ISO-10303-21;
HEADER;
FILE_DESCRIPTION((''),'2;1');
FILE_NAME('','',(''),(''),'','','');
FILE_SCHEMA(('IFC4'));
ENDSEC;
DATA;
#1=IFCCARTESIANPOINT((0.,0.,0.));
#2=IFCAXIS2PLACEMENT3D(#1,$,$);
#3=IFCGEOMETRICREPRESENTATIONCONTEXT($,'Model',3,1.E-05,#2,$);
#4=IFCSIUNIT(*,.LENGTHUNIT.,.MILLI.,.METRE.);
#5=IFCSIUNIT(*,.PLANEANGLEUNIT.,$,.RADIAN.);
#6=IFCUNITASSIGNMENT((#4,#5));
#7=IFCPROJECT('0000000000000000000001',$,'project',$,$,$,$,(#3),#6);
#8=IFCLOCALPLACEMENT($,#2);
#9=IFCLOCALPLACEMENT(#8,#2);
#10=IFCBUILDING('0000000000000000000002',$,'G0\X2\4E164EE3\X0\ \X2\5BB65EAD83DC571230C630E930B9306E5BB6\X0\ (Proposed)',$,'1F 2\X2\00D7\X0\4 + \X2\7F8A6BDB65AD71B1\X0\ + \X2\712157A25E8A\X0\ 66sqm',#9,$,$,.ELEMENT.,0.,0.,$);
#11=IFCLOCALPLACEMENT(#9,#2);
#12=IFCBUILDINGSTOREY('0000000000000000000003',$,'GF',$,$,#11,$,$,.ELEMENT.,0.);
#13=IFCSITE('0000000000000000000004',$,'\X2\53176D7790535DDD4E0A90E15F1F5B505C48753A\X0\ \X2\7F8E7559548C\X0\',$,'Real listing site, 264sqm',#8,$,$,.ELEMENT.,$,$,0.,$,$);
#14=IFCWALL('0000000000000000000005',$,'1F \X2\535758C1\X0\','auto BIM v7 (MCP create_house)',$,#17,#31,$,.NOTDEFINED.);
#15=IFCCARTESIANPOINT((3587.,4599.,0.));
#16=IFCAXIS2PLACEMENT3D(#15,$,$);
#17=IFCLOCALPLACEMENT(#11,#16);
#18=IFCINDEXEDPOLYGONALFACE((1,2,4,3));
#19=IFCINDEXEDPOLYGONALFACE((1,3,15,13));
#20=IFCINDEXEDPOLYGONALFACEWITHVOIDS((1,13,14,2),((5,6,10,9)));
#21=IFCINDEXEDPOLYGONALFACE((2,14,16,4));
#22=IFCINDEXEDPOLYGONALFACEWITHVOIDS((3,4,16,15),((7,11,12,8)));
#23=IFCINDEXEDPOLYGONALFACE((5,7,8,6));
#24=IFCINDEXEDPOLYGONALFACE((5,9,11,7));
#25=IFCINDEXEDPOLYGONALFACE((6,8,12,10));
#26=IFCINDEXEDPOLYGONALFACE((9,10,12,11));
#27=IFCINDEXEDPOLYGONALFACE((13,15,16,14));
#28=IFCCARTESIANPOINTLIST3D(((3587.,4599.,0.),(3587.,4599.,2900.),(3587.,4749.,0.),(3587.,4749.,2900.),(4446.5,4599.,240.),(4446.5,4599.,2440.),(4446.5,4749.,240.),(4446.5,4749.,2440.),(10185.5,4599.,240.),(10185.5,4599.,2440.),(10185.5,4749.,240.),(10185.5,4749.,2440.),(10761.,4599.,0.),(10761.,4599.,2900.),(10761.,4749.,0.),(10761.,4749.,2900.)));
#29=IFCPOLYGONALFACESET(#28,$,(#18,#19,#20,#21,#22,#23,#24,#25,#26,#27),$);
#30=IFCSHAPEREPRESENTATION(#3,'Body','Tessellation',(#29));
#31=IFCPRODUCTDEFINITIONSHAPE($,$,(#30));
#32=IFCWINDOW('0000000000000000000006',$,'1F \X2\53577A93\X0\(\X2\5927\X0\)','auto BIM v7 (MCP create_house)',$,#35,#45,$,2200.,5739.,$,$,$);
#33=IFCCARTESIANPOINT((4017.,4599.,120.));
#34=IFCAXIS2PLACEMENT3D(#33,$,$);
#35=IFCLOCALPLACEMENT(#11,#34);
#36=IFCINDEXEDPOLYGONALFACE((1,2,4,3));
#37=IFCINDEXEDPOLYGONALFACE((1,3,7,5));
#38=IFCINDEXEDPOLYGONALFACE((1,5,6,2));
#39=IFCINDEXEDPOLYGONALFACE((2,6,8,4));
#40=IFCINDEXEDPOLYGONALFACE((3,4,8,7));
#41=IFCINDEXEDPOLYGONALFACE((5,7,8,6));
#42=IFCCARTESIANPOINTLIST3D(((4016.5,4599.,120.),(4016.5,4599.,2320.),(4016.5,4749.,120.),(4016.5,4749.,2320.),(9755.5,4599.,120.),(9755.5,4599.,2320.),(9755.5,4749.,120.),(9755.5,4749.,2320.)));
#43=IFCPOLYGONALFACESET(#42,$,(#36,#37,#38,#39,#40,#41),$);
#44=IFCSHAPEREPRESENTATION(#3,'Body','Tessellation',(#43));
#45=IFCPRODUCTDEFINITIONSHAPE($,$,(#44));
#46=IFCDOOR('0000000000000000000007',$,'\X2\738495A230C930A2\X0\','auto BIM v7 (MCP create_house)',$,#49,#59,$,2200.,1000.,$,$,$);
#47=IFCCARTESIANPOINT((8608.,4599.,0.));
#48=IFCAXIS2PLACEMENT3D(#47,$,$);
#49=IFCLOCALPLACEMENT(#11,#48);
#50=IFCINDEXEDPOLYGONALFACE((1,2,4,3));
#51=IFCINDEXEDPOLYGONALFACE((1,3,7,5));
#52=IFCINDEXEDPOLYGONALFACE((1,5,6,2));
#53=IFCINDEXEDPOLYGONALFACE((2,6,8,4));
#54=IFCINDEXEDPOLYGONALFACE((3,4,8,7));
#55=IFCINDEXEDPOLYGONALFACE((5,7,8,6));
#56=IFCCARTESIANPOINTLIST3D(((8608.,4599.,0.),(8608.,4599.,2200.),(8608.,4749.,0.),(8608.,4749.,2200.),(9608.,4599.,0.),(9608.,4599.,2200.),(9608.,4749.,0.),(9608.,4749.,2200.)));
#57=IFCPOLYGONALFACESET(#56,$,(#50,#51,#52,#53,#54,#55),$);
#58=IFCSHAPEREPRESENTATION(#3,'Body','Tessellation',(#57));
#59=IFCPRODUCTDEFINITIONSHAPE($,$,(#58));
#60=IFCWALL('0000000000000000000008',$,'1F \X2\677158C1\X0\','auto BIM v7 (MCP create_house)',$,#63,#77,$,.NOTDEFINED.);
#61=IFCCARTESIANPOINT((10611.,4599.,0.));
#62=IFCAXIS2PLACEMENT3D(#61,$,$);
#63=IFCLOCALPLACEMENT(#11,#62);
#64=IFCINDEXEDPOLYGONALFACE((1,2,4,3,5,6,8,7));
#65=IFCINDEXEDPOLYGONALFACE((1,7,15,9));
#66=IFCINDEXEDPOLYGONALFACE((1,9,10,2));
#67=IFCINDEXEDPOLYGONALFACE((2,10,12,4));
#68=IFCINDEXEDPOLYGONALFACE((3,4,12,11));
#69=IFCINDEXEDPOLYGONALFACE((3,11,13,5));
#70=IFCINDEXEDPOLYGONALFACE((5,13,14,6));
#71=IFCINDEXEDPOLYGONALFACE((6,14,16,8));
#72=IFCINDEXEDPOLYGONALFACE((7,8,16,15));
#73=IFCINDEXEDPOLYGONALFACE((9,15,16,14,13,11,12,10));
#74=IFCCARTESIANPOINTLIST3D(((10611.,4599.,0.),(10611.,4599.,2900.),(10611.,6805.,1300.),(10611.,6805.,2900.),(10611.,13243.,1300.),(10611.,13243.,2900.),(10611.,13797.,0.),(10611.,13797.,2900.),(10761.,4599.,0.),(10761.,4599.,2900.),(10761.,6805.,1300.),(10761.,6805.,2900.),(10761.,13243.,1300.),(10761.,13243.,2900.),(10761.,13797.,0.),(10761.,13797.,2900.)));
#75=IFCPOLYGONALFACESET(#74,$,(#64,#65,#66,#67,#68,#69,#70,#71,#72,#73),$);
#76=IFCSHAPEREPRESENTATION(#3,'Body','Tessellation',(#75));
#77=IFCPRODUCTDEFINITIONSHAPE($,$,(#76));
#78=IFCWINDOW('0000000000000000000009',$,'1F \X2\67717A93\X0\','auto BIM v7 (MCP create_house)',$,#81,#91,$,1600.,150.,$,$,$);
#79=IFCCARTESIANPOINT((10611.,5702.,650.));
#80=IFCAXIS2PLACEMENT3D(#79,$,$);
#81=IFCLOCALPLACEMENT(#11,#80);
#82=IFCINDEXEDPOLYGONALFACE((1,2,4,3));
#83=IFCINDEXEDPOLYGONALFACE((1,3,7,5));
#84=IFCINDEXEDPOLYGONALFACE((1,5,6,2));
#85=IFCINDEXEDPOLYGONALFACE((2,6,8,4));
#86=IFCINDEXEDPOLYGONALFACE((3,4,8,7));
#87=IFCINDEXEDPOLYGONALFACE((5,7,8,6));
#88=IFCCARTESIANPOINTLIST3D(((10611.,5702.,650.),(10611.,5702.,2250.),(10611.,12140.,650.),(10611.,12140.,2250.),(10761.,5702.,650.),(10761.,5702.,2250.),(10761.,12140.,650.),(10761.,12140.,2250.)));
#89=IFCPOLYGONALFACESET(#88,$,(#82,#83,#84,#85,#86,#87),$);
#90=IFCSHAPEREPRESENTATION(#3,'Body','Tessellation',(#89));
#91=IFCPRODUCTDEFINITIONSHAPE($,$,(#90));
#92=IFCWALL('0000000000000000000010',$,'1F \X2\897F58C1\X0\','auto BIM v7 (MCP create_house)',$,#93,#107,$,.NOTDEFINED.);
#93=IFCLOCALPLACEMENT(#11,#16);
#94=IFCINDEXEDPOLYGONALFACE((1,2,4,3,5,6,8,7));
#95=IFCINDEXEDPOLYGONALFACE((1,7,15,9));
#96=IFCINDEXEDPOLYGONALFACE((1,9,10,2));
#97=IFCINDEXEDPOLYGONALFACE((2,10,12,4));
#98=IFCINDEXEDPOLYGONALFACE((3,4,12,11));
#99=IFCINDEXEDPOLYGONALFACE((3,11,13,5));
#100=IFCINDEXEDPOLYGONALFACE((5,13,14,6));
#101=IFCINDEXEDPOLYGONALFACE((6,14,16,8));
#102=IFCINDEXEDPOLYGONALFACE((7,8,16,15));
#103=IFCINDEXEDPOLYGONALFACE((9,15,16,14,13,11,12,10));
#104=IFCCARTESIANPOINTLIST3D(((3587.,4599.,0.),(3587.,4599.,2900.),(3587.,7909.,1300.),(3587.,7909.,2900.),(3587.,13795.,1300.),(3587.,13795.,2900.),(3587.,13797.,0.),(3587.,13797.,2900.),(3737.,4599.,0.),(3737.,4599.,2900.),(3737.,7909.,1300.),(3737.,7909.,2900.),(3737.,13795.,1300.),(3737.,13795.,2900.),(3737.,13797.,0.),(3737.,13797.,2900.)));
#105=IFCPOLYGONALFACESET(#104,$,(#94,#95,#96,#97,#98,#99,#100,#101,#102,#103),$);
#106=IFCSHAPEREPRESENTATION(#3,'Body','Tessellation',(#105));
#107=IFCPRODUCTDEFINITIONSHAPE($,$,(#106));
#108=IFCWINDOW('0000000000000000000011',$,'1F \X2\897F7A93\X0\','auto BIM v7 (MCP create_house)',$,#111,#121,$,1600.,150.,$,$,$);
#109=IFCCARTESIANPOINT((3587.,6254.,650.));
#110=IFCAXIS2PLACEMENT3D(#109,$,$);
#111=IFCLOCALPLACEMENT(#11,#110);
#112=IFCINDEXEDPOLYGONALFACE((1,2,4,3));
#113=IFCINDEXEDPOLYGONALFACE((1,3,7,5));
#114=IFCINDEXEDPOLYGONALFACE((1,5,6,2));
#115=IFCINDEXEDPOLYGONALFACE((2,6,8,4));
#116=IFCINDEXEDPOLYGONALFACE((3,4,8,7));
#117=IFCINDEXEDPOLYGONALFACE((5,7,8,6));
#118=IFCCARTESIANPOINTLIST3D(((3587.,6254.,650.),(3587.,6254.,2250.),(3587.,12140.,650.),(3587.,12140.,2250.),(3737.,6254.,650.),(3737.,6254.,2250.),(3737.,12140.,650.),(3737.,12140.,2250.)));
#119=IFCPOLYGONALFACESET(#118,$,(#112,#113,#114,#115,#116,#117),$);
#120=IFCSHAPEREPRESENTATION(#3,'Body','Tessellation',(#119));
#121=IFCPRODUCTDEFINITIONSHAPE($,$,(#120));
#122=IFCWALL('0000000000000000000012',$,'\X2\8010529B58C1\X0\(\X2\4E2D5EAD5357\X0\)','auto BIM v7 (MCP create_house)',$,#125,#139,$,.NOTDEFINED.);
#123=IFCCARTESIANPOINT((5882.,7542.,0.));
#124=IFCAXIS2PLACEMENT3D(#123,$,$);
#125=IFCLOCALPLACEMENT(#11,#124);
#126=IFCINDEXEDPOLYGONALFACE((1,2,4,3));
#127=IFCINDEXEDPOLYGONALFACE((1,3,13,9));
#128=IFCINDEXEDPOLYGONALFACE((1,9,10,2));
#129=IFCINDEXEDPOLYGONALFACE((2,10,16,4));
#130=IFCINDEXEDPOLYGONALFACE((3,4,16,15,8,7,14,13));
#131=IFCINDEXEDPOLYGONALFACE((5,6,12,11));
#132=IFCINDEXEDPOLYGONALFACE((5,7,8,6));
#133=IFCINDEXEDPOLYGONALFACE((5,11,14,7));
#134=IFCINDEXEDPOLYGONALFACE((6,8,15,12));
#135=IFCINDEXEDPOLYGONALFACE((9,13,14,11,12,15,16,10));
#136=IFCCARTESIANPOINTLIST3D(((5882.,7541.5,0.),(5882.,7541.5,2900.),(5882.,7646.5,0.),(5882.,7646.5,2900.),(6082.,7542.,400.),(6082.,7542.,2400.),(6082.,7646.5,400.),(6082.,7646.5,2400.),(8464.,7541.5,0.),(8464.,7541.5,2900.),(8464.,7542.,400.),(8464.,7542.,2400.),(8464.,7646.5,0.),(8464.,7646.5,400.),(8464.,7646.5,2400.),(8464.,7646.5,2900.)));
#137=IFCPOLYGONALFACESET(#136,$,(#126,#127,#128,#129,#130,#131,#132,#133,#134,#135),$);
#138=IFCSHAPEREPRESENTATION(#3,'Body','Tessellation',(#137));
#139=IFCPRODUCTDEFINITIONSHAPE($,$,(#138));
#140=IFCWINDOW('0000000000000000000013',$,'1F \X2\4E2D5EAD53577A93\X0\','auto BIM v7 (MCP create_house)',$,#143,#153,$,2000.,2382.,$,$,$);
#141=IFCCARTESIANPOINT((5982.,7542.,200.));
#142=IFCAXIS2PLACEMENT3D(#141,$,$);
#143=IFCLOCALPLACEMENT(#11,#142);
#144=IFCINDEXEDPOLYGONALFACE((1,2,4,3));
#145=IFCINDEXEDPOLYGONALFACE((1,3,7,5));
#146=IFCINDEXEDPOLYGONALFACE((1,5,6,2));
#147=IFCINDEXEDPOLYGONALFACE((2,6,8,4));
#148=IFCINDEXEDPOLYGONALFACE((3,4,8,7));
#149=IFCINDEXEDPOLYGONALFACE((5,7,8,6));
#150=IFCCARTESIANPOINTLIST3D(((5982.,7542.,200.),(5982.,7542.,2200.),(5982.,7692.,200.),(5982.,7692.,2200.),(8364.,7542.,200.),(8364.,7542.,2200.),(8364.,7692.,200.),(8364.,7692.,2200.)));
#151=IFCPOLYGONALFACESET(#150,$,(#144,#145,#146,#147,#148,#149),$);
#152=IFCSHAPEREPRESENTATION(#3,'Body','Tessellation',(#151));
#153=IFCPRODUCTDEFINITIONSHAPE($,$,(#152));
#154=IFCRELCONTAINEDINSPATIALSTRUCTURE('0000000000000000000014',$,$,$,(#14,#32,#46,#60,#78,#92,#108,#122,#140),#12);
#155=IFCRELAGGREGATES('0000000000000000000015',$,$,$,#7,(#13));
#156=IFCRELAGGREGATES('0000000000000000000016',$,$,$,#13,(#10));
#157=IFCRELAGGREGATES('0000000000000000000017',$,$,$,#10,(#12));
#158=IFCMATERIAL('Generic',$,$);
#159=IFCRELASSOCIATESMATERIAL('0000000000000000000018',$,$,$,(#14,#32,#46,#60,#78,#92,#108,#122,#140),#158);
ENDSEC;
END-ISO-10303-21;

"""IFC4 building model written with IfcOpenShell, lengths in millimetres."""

from ifc_helpers import new_model, si_unit, frame, frame_2d, origin, place, context, project, spatial, rectangle, extrude, material, element, fill, save


model = new_model("IFC4")

# Units and contexts
model_context = context("Model", 3, precision=1e-05, world=origin())
ifc_project = project(units=[si_unit("LENGTHUNIT", "METRE", prefix="MILLI"), si_unit("PLANEANGLEUNIT", "RADIAN")], contexts=[model_context])

# Site, building, storey
site_placement = place(None, origin())
site = spatial("IfcSite", under=ifc_project, at=site_placement, Name="北海道川上郡弟子屈町 美留和", ObjectType="Real listing site, 264sqm", CompositionType="ELEMENT", RefElevation=0.0)
building_placement = place(site_placement, origin())
building = spatial("IfcBuilding", under=site, at=building_placement, Name="G0世代 家庭菜園テラスの家 (Proposed)", ObjectType="1F 2×4 + 羊毛断熱 + 無垢床 66sqm", CompositionType="ELEMENT", ElevationOfRefHeight=0.0, ElevationOfTerrain=0.0)
storey_placement = place(building_placement, origin())
storey = spatial("IfcBuildingStorey", under=building, at=storey_placement, Name="GF", CompositionType="ELEMENT", Elevation=0.0)

# Shared definitions
ifc_material = material(Name="Generic")

# Wall, openings, window, door
wall_1_placement = place(storey_placement, frame((3587.0, 4599.0, 0.0)))
wall_1 = element("IfcWall", 1, at=wall_1_placement, inside=storey, material=ifc_material, Name="1F 南壁", Description="auto BIM v7 (MCP create_house)", PredefinedType="NOTDEFINED", context=model_context, shape_type="SweptSolid", body=[
    extrude(rectangle(XDim=7174.0, YDim=150.0, at=frame_2d((3587.0, 75.0))), frame((3587.0, 4599.0, 0.0)), (0.0, 0.0, 1.0), 2900.0),
])
opening_1_placement = place(storey_placement, frame((4017.0, 4599.0, 120.0)))
opening_1 = element("IfcOpeningElement", 2, at=opening_1_placement, cuts=wall_1, PredefinedType="NOTDEFINED", context=model_context, shape_type="SweptSolid", body=[
    extrude(rectangle(XDim=5739.0, YDim=150.0, at=frame_2d((2869.0, 75.0))), frame((4017.0, 4599.0, 120.0)), (0.0, 0.0, 1.0), 2200.0),
])
opening_2_placement = place(storey_placement, frame((8608.0, 4599.0, 0.0)))
opening_2 = element("IfcOpeningElement", 3, at=opening_2_placement, cuts=wall_1, PredefinedType="NOTDEFINED", context=model_context, shape_type="SweptSolid", body=[
    extrude(rectangle(XDim=1000.0, YDim=150.0, at=frame_2d((500.0, 75.0))), frame((8608.0, 4599.0, 0.0)), (0.0, 0.0, 1.0), 2200.0),
])
window_1_placement = place(storey_placement, frame((4017.0, 4599.0, 120.0)))
window_1 = element("IfcWindow", 4, at=window_1_placement, inside=storey, material=ifc_material, Name="1F 南窓(大)", Description="auto BIM v7 (MCP create_house)", OverallHeight=2200.0, OverallWidth=5739.0, context=model_context, shape_type="SweptSolid", body=[
    extrude(rectangle(XDim=5739.0, YDim=150.0, at=frame_2d((2869.0, 75.0))), frame((4017.0, 4599.0, 120.0)), (0.0, 0.0, 1.0), 2200.0),
])
fill(opening_1, window_1)
door_placement = place(storey_placement, frame((8608.0, 4599.0, 0.0)))
door = element("IfcDoor", 5, at=door_placement, inside=storey, material=ifc_material, Name="玄関ドア", Description="auto BIM v7 (MCP create_house)", OverallHeight=2200.0, OverallWidth=1000.0, context=model_context, shape_type="SweptSolid", body=[
    extrude(rectangle(XDim=1000.0, YDim=150.0, at=frame_2d((500.0, 75.0))), frame((8608.0, 4599.0, 0.0)), (0.0, 0.0, 1.0), 2200.0),
])
fill(opening_2, door)

# Walls, openings, windows
wall_2_placement = place(storey_placement, frame((10611.0, 4599.0, 0.0)))
wall_2 = element("IfcWall", 6, at=wall_2_placement, inside=storey, material=ifc_material, Name="1F 東壁", Description="auto BIM v7 (MCP create_house)", PredefinedType="NOTDEFINED", context=model_context, shape_type="SweptSolid", body=[
    extrude(rectangle(XDim=150.0, YDim=9198.0, at=frame_2d((75.0, 4599.0))), frame((10611.0, 4599.0, 0.0)), (0.0, 0.0, 1.0), 2900.0),
])
opening_3_placement = place(storey_placement, frame((10611.0, 5702.0, 650.0)))
opening_3 = element("IfcOpeningElement", 7, at=opening_3_placement, cuts=wall_2, PredefinedType="NOTDEFINED", context=model_context, shape_type="SweptSolid", body=[
    extrude(rectangle(XDim=150.0, YDim=6438.0, at=frame_2d((75.0, 3219.0))), frame((10611.0, 5702.0, 650.0)), (0.0, 0.0, 1.0), 1600.0),
])
window_2_placement = place(storey_placement, frame((10611.0, 5702.0, 650.0)))
window_2 = element("IfcWindow", 8, at=window_2_placement, inside=storey, material=ifc_material, Name="1F 東窓", Description="auto BIM v7 (MCP create_house)", OverallHeight=1600.0, OverallWidth=150.0, context=model_context, shape_type="SweptSolid", body=[
    extrude(rectangle(XDim=150.0, YDim=6438.0, at=frame_2d((75.0, 3219.0))), frame((10611.0, 5702.0, 650.0)), (0.0, 0.0, 1.0), 1600.0),
])
fill(opening_3, window_2)
wall_3_placement = place(storey_placement, frame((3587.0, 4599.0, 0.0)))
wall_3 = element("IfcWall", 9, at=wall_3_placement, inside=storey, material=ifc_material, Name="1F 西壁", Description="auto BIM v7 (MCP create_house)", PredefinedType="NOTDEFINED", context=model_context, shape_type="SweptSolid", body=[
    extrude(rectangle(XDim=150.0, YDim=9198.0, at=frame_2d((75.0, 4599.0))), frame((3587.0, 4599.0, 0.0)), (0.0, 0.0, 1.0), 2900.0),
])
opening_4_placement = place(storey_placement, frame((3587.0, 6254.0, 650.0)))
opening_4 = element("IfcOpeningElement", 10, at=opening_4_placement, cuts=wall_3, PredefinedType="NOTDEFINED", context=model_context, shape_type="SweptSolid", body=[
    extrude(rectangle(XDim=150.0, YDim=5886.0, at=frame_2d((75.0, 2943.0))), frame((3587.0, 6254.0, 650.0)), (0.0, 0.0, 1.0), 1600.0),
])
window_3_placement = place(storey_placement, frame((3587.0, 6254.0, 650.0)))
window_3 = element("IfcWindow", 11, at=window_3_placement, inside=storey, material=ifc_material, Name="1F 西窓", Description="auto BIM v7 (MCP create_house)", OverallHeight=1600.0, OverallWidth=150.0, context=model_context, shape_type="SweptSolid", body=[
    extrude(rectangle(XDim=150.0, YDim=5886.0, at=frame_2d((75.0, 2943.0))), frame((3587.0, 6254.0, 650.0)), (0.0, 0.0, 1.0), 1600.0),
])
fill(opening_4, window_3)
wall_4_placement = place(storey_placement, frame((5882.0, 7542.0, 0.0)))
wall_4 = element("IfcWall", 12, at=wall_4_placement, inside=storey, material=ifc_material, Name="耐力壁(中庭南)", Description="auto BIM v7 (MCP create_house)", PredefinedType="NOTDEFINED", context=model_context, shape_type="SweptSolid", body=[
    extrude(rectangle(XDim=2582.0, YDim=105.0, at=frame_2d((1291.0, 52.0))), frame((5882.0, 7542.0, 0.0)), (0.0, 0.0, 1.0), 2900.0),
])
opening_5_placement = place(storey_placement, frame((5982.0, 7542.0, 200.0)))
opening_5 = element("IfcOpeningElement", 13, at=opening_5_placement, cuts=wall_4, PredefinedType="NOTDEFINED", context=model_context, shape_type="SweptSolid", body=[
    extrude(rectangle(XDim=2382.0, YDim=150.0, at=frame_2d((1191.0, 75.0))), frame((5982.0, 7542.0, 200.0)), (0.0, 0.0, 1.0), 2000.0),
])
window_4_placement = place(storey_placement, frame((5982.0, 7542.0, 200.0)))
window_4 = element("IfcWindow", 14, at=window_4_placement, inside=storey, material=ifc_material, Name="1F 中庭南窓", Description="auto BIM v7 (MCP create_house)", OverallHeight=2000.0, OverallWidth=2382.0, context=model_context, shape_type="SweptSolid", body=[
    extrude(rectangle(XDim=2382.0, YDim=150.0, at=frame_2d((1191.0, 75.0))), frame((5982.0, 7542.0, 200.0)), (0.0, 0.0, 1.0), 2000.0),
])
fill(opening_5, window_4)

save(model, "model.ifc")
